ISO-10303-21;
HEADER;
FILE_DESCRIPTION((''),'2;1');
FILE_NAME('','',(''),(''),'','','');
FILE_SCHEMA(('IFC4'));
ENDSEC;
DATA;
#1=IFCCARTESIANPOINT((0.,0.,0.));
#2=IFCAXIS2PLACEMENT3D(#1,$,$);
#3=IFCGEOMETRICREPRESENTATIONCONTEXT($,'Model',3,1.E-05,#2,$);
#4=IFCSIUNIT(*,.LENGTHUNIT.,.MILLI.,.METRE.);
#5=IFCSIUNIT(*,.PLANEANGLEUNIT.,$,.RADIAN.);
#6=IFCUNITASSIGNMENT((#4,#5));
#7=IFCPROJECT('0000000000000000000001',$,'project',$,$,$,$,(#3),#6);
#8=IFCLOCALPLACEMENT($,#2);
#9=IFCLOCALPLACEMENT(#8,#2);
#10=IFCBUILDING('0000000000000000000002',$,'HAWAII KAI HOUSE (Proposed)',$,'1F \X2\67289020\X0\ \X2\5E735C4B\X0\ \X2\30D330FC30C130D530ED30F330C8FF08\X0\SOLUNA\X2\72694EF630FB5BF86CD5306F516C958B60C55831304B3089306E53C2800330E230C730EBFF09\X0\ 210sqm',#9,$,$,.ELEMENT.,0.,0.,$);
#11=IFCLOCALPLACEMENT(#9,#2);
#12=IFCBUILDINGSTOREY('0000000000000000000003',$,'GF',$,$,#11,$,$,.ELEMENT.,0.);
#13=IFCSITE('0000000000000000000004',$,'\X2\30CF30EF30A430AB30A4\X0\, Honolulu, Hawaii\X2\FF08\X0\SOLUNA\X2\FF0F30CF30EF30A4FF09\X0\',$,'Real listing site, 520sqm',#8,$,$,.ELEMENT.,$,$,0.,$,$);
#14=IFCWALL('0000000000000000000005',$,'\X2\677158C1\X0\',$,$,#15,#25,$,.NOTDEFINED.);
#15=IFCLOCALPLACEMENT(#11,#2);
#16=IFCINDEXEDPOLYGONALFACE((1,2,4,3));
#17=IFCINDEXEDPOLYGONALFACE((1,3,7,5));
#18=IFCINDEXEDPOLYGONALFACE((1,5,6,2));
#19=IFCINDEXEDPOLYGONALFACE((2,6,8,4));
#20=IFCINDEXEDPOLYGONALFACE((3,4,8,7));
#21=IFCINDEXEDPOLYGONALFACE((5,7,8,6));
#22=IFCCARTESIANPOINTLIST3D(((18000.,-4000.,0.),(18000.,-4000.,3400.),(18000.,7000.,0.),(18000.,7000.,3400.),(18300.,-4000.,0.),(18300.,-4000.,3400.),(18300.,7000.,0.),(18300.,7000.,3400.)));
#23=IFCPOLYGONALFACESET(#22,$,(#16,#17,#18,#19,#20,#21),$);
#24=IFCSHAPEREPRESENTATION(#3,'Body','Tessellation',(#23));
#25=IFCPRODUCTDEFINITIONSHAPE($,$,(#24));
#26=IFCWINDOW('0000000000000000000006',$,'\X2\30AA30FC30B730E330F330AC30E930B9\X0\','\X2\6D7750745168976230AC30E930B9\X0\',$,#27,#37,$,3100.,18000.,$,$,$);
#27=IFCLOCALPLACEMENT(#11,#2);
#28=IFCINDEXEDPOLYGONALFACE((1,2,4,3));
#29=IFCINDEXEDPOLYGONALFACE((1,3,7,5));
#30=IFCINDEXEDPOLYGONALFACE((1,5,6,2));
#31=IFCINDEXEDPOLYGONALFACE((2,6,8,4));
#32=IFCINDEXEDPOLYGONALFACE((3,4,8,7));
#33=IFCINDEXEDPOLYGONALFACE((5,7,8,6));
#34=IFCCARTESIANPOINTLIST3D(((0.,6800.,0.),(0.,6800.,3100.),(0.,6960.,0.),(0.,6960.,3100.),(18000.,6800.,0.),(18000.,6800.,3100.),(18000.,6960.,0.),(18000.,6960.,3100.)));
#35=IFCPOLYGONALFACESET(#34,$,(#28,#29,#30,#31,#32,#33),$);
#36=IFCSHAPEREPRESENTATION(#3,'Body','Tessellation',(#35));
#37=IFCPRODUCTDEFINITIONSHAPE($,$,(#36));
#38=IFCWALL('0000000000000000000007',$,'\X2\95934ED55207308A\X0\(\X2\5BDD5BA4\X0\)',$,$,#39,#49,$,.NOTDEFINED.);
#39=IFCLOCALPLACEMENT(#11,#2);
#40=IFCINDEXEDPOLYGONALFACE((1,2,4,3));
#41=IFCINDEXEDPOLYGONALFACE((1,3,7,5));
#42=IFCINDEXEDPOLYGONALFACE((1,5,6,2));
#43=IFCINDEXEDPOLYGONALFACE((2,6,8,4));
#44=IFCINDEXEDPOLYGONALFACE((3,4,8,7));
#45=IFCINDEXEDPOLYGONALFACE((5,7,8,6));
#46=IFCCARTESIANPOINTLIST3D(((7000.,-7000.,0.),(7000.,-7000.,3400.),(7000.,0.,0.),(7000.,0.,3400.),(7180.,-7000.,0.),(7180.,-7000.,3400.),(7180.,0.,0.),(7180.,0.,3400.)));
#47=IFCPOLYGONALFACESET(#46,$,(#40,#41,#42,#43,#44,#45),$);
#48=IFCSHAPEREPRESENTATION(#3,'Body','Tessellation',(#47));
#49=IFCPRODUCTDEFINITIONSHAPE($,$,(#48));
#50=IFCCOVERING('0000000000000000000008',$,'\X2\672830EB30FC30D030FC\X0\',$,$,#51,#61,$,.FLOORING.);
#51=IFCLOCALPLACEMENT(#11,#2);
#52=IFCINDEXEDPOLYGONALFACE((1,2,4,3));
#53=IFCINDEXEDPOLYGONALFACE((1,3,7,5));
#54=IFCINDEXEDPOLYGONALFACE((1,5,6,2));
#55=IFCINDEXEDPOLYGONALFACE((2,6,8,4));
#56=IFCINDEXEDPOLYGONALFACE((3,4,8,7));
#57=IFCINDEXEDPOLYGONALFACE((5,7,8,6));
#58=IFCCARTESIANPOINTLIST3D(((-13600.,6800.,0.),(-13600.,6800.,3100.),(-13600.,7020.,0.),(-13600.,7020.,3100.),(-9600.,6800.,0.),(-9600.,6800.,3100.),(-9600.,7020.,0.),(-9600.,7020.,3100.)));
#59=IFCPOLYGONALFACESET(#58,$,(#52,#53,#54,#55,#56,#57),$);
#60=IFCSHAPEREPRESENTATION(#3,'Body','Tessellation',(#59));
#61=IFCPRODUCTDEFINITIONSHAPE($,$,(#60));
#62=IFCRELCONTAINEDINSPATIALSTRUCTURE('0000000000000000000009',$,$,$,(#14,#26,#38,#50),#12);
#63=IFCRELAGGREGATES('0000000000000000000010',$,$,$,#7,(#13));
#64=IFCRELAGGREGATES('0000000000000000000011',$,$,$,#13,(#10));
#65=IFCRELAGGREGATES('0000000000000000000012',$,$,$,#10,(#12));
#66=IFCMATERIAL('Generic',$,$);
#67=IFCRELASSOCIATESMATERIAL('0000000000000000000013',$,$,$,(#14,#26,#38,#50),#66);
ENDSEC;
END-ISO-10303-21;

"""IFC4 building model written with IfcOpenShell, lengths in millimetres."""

from ifc_helpers import new_model, si_unit, frame, frame_2d, origin, place, context, project, spatial, rectangle, extrude, material, element, fill, save


model = new_model("IFC4")

# Units and contexts
model_context = context("Model", 3, precision=1e-05, world=origin())
ifc_project = project(units=[si_unit("LENGTHUNIT", "METRE", prefix="MILLI"), si_unit("PLANEANGLEUNIT", "RADIAN")], contexts=[model_context])

# Site, building, storey
site_placement = place(None, origin())
site = spatial("IfcSite", under=ifc_project, at=site_placement, Name="ハワイカイ, Honolulu, Hawaii（SOLUNA／ハワイ）", ObjectType="Real listing site, 520sqm", CompositionType="ELEMENT", RefElevation=0.0)
building_placement = place(site_placement, origin())
building = spatial("IfcBuilding", under=site, at=building_placement, Name="HAWAII KAI HOUSE (Proposed)", ObjectType="1F 木造 平屋 ビーチフロント（SOLUNA物件・寸法は公開情報からの参考モデル） 210sqm", CompositionType="ELEMENT", ElevationOfRefHeight=0.0, ElevationOfTerrain=0.0)
storey_placement = place(building_placement, origin())
storey = spatial("IfcBuildingStorey", under=building, at=storey_placement, Name="GF", CompositionType="ELEMENT", Elevation=0.0)

# Shared definitions
ifc_material_1 = material(Name="Generic")

# Wall, opening, window
wall_1_placement = place(storey_placement, frame((9000.0, -2000.0, 0.0)))
wall_1 = element("IfcWall", 1, at=wall_1_placement, inside=storey, material=ifc_material_1, Name="東壁", PredefinedType="NOTDEFINED", context=model_context, shape_type="SweptSolid", body=[
    extrude(rectangle(XDim=300.0, YDim=11000.0, at=frame_2d((150.0, 5500.0))), frame((9000.0, -2000.0, 0.0)), (0.0, 0.0, 1.0), 3400.0),
])
opening_placement = place(storey_placement, frame((0.0, 3400.0, 0.0)))
opening = element("IfcOpeningElement", 2, at=opening_placement, cuts=wall_1, PredefinedType="NOTDEFINED", context=model_context, shape_type="SweptSolid", body=[
    extrude(rectangle(XDim=18000.0, YDim=160.0, at=frame_2d((9000.0, 80.0))), frame((0.0, 3400.0, 0.0)), (0.0, 0.0, 1.0), 3100.0),
])
window_placement = place(storey_placement, frame((0.0, 3400.0, 0.0)))
window = element("IfcWindow", 3, at=window_placement, inside=storey, material=ifc_material_1, Name="オーシャンガラス", Description="海側全面ガラス", OverallHeight=3100.0, OverallWidth=18000.0, context=model_context, shape_type="SweptSolid", body=[
    extrude(rectangle(XDim=18000.0, YDim=160.0, at=frame_2d((9000.0, 80.0))), frame((0.0, 3400.0, 0.0)), (0.0, 0.0, 1.0), 3100.0),
])
fill(opening, window)

# Wall
wall_2_placement = place(storey_placement, frame((3500.0, -3500.0, 0.0)))
element("IfcWall", 4, at=wall_2_placement, inside=storey, material=ifc_material_1, Name="間仕切り(寝室)", PredefinedType="NOTDEFINED", context=model_context, shape_type="SweptSolid", body=[
    extrude(rectangle(XDim=180.0, YDim=7000.0, at=frame_2d((90.0, 3500.0))), frame((3500.0, -3500.0, 0.0)), (0.0, 0.0, 1.0), 3400.0),
])

# Covering
covering_placement = place(storey_placement, frame((-6800.0, 3400.0, 0.0)))
element("IfcCovering", 5, at=covering_placement, inside=storey, material=ifc_material_1, Name="木ルーバー", PredefinedType="FLOORING", context=model_context, shape_type="SweptSolid", body=[
    extrude(rectangle(XDim=4000.0, YDim=220.0, at=frame_2d((2000.0, 110.0))), frame((-6800.0, 3400.0, 0.0)), (0.0, 0.0, 1.0), 3100.0),
])

save(model, "model.ifc")
